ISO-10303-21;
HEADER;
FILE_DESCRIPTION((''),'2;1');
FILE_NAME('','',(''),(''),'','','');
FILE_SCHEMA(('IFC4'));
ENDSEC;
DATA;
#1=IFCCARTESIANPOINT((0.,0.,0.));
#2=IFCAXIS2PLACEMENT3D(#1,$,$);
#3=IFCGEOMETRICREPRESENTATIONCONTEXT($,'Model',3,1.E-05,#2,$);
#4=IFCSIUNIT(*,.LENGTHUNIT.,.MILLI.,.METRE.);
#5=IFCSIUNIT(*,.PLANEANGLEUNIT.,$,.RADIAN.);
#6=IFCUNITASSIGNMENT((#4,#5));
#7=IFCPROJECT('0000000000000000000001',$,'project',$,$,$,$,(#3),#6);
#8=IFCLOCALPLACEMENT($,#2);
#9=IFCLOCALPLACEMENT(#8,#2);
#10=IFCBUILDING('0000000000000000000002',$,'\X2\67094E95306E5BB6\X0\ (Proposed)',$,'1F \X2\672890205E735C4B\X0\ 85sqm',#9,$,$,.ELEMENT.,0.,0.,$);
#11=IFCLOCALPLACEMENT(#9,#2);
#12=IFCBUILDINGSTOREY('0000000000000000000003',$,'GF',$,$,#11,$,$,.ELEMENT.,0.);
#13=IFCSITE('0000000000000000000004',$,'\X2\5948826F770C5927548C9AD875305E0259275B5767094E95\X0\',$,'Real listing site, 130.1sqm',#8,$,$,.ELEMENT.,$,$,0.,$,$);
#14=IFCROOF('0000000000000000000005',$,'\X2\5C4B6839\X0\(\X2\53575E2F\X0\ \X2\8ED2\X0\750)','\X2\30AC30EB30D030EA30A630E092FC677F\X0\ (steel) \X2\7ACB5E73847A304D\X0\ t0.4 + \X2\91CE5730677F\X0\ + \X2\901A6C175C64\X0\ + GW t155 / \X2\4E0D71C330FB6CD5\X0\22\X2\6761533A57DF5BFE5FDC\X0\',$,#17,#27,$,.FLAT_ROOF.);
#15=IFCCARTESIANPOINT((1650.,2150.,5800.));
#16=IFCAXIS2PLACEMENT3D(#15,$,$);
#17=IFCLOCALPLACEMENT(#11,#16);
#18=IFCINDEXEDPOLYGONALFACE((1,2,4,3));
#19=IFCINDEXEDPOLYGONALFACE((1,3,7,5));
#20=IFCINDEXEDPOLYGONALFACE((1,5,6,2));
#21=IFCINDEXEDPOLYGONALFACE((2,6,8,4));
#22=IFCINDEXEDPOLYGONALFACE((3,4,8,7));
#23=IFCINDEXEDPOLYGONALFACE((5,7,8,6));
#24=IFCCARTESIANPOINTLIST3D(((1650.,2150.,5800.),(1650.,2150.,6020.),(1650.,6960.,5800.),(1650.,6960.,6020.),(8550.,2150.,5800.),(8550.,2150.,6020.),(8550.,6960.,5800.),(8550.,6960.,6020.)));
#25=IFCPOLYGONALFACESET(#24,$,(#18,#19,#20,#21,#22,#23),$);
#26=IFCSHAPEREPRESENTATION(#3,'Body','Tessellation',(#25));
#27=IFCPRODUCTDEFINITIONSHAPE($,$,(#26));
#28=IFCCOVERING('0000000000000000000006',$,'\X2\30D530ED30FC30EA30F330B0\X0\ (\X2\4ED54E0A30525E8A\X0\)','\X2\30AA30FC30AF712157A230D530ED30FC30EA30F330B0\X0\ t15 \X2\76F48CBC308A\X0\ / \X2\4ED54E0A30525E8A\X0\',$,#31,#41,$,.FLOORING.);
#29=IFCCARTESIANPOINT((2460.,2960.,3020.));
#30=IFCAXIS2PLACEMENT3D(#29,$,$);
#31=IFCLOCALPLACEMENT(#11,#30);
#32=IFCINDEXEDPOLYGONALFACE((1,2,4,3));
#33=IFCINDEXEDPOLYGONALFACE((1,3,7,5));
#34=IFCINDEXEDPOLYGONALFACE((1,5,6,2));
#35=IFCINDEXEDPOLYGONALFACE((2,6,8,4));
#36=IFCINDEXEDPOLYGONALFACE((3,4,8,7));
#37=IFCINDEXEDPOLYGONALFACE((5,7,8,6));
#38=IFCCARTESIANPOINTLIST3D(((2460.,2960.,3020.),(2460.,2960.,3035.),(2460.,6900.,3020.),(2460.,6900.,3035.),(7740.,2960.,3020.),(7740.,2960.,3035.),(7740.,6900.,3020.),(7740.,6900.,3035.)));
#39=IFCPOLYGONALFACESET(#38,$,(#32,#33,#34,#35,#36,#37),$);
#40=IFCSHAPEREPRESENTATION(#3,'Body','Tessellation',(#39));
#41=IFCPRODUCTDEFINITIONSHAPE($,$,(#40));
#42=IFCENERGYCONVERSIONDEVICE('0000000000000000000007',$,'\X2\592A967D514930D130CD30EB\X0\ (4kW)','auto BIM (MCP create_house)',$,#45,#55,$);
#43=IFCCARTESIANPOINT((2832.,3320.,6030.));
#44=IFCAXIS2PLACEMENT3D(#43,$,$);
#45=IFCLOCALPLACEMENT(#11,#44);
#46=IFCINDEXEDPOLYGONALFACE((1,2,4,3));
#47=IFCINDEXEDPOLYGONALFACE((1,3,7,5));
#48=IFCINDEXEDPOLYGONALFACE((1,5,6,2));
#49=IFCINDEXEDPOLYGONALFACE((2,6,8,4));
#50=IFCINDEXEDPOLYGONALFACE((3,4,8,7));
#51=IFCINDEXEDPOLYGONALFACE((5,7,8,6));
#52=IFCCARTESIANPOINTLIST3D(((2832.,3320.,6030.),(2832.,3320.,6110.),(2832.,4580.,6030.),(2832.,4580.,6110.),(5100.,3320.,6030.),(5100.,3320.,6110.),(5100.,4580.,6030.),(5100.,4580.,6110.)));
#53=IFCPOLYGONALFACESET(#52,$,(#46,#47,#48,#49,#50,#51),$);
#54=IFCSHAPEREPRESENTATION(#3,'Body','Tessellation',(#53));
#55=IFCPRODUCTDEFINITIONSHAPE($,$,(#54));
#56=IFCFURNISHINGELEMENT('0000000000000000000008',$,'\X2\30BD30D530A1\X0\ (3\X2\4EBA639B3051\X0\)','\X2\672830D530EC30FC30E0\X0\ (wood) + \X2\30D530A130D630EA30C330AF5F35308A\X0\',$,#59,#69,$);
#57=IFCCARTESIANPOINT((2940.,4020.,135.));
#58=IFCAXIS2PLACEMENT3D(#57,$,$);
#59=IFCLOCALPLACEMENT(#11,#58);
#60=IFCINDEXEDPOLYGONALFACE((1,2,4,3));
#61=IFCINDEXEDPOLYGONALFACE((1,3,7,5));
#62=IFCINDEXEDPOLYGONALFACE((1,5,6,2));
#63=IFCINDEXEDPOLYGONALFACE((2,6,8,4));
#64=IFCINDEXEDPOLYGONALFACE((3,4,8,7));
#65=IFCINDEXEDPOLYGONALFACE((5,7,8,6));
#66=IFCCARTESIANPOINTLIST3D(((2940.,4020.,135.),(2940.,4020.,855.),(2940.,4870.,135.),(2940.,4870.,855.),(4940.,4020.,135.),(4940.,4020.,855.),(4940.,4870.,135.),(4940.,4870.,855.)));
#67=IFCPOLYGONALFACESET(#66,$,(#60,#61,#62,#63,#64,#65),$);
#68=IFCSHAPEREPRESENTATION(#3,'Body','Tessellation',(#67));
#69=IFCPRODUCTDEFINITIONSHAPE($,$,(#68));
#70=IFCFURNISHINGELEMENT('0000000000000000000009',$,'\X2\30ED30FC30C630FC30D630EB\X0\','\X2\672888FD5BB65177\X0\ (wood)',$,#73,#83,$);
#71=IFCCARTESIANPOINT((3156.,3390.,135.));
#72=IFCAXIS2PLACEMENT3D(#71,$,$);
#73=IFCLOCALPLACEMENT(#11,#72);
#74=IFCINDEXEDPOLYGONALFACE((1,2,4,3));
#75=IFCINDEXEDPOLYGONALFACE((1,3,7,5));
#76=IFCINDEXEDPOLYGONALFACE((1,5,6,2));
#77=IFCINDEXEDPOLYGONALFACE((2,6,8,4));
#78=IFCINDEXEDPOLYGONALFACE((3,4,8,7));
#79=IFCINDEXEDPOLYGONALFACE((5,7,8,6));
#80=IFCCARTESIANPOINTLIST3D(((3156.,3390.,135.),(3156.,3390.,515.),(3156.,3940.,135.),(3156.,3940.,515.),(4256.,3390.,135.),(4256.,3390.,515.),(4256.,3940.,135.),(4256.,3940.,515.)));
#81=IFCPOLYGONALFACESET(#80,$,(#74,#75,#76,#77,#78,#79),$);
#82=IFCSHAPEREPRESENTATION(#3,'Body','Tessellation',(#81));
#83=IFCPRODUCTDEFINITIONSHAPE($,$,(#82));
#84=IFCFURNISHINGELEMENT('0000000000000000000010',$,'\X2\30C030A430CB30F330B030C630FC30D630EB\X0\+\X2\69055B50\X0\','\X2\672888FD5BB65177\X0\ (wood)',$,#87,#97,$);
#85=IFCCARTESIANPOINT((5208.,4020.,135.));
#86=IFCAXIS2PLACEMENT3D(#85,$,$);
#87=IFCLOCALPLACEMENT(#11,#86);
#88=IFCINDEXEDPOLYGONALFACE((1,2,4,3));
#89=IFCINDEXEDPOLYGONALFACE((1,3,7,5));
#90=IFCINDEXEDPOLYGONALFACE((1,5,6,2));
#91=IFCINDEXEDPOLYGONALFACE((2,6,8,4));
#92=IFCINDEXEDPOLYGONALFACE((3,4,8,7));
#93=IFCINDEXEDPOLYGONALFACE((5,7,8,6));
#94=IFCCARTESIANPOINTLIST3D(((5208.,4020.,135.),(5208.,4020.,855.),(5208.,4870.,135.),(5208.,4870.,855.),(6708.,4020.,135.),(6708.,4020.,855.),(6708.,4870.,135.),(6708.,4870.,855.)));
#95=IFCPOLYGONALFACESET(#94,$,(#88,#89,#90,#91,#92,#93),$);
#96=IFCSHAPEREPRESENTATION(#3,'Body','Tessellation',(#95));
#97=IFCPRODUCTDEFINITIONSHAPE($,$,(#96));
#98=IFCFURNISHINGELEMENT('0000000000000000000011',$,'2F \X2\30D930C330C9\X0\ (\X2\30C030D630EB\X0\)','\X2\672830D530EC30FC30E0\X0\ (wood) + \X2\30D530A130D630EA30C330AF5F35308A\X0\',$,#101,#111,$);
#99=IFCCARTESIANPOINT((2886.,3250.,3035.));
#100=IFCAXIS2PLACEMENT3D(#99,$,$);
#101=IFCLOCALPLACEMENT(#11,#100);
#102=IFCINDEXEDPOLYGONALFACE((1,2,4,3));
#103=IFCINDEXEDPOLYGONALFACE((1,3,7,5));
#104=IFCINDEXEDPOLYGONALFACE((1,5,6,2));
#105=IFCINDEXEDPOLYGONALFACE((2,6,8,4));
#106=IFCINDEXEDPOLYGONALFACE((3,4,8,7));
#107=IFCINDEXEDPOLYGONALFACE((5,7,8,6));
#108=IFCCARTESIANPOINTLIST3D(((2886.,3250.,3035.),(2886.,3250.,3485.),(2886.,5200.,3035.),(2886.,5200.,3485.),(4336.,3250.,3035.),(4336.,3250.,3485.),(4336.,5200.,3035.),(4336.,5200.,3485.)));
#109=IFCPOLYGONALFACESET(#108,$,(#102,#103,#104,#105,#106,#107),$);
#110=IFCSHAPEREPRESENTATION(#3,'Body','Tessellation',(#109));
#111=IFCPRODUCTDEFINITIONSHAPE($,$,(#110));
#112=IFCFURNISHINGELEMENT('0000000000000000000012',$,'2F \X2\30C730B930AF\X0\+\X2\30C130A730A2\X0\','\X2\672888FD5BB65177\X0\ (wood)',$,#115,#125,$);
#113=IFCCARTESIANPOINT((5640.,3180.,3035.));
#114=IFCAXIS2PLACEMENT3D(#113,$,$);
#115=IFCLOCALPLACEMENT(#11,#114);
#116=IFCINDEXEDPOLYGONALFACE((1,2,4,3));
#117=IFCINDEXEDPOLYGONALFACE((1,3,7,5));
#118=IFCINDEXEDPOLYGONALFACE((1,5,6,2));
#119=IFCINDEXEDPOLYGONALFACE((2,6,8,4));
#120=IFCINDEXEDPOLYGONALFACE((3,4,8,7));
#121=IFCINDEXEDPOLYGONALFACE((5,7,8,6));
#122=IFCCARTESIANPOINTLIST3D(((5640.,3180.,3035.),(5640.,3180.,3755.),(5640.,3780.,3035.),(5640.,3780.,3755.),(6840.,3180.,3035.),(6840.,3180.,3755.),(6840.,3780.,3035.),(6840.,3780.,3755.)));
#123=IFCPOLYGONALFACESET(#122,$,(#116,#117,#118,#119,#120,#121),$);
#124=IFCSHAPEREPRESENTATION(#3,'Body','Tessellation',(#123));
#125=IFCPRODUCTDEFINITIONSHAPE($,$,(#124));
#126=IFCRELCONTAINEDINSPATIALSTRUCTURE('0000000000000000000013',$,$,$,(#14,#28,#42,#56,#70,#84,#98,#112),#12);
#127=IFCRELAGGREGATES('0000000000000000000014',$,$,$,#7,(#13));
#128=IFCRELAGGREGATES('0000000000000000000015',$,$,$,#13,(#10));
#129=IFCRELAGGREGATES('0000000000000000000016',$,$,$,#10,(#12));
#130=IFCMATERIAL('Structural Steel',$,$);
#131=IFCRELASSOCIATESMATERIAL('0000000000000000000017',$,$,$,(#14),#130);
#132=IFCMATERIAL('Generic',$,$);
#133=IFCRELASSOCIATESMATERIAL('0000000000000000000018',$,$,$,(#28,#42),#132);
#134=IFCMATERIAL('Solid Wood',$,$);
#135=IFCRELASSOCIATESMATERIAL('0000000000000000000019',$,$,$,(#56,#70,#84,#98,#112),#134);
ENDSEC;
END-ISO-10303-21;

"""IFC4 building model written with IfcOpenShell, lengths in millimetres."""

from ifc_helpers import new_model, si_unit, frame, frame_2d, origin, place, context, project, spatial, rectangle, extrude, material, element, save


model = new_model("IFC4")

# Units and contexts
model_context = context("Model", 3, precision=1e-05, world=origin())
ifc_project = project(units=[si_unit("LENGTHUNIT", "METRE", prefix="MILLI"), si_unit("PLANEANGLEUNIT", "RADIAN")], contexts=[model_context])

# Site, building, storey
site_placement = place(None, origin())
site = spatial("IfcSite", under=ifc_project, at=site_placement, Name="奈良県大和高田市大字有井", ObjectType="Real listing site, 130.1sqm", CompositionType="ELEMENT", RefElevation=0.0)
building_placement = place(site_placement, origin())
building = spatial("IfcBuilding", under=site, at=building_placement, Name="有井の家 (Proposed)", ObjectType="1F 木造平屋 85sqm", CompositionType="ELEMENT", ElevationOfRefHeight=0.0, ElevationOfTerrain=0.0)
storey_placement = place(building_placement, origin())
storey = spatial("IfcBuildingStorey", under=building, at=storey_placement, Name="GF", CompositionType="ELEMENT", Elevation=0.0)

# Shared definitions
ifc_material_1 = material(Name="Solid Wood")

# Shared definitions
ifc_material_2 = material(Name="Generic")

# Roof
ifc_material_3 = material(Name="Structural Steel")
for number, where, name in (
    (1, (1650.0, 2150.0, 5800.0), "屋根(南帯 軒750)"),
):
    element("IfcRoof", number, at=place(storey_placement, frame(where)), inside=storey, material=ifc_material_3, Name=name, Description="ガルバリウム鋼板 (steel) 立平葺き t0.4 + 野地板 + 通気層 + GW t155 / 不燃・法22条区域対応", PredefinedType="FLAT_ROOF", context=model_context, shape_type="SweptSolid", body=[
        extrude(rectangle(XDim=6900.0, YDim=4810.0, at=frame_2d((3450.0, 2405.0))), frame((1650.0, 2150.0, 5800.0)), (0.0, 0.0, 1.0), 220.0),
    ])

# Covering
covering_placement = place(storey_placement, frame((2460.0, 2960.0, 3020.0)))
element("IfcCovering", 2, at=covering_placement, inside=storey, material=ifc_material_2, Name="フローリング (仕上げ床)", Description="オーク無垢フローリング t15 直貼り / 仕上げ床", PredefinedType="FLOORING", context=model_context, shape_type="SweptSolid", body=[
    extrude(rectangle(XDim=5280.0, YDim=3940.0, at=frame_2d((2640.0, 1970.0))), frame((2460.0, 2960.0, 3020.0)), (0.0, 0.0, 1.0), 15.0),
])

# Energy conversion device
energy_conversion_device_placement = place(storey_placement, frame((2832.0, 3320.0, 6030.0)))
element("IfcEnergyConversionDevice", 3, at=energy_conversion_device_placement, inside=storey, material=ifc_material_2, Name="太陽光パネル (4kW)", Description="auto BIM (MCP create_house)", context=model_context, shape_type="SweptSolid", body=[
    extrude(rectangle(XDim=2268.0, YDim=1260.0, at=frame_2d((1134.0, 630.0))), frame((2832.0, 3320.0, 6030.0)), (0.0, 0.0, 1.0), 80.0),
])

# Furnishing elements
furnishing_1_placement = place(storey_placement, frame((2940.0, 4020.0, 135.0)))
element("IfcFurnishingElement", 4, at=furnishing_1_placement, inside=storey, material=ifc_material_1, Name="ソファ (3人掛け)", Description="木フレーム (wood) + ファブリック張り", context=model_context, shape_type="SweptSolid", body=[
    extrude(rectangle(XDim=2000.0, YDim=850.0, at=frame_2d((1000.0, 425.0))), frame((2940.0, 4020.0, 135.0)), (0.0, 0.0, 1.0), 720.0),
])
furnishing_2_placement = place(storey_placement, frame((3156.0, 3390.0, 135.0)))
element("IfcFurnishingElement", 5, at=furnishing_2_placement, inside=storey, material=ifc_material_1, Name="ローテーブル", Description="木製家具 (wood)", context=model_context, shape_type="SweptSolid", body=[
    extrude(rectangle(XDim=1100.0, YDim=550.0, at=frame_2d((550.0, 275.0))), frame((3156.0, 3390.0, 135.0)), (0.0, 0.0, 1.0), 380.0),
])
furnishing_3_placement = place(storey_placement, frame((5208.0, 4020.0, 135.0)))
element("IfcFurnishingElement", 6, at=furnishing_3_placement, inside=storey, material=ifc_material_1, Name="ダイニングテーブル+椅子", Description="木製家具 (wood)", context=model_context, shape_type="SweptSolid", body=[
    extrude(rectangle(XDim=1500.0, YDim=850.0, at=frame_2d((750.0, 425.0))), frame((5208.0, 4020.0, 135.0)), (0.0, 0.0, 1.0), 720.0),
])
furnishing_4_placement = place(storey_placement, frame((2886.0, 3250.0, 3035.0)))
element("IfcFurnishingElement", 7, at=furnishing_4_placement, inside=storey, material=ifc_material_1, Name="2F ベッド (ダブル)", Description="木フレーム (wood) + ファブリック張り", context=model_context, shape_type="SweptSolid", body=[
    extrude(rectangle(XDim=1450.0, YDim=1950.0, at=frame_2d((725.0, 975.0))), frame((2886.0, 3250.0, 3035.0)), (0.0, 0.0, 1.0), 450.0),
])
furnishing_5_placement = place(storey_placement, frame((5640.0, 3180.0, 3035.0)))
element("IfcFurnishingElement", 8, at=furnishing_5_placement, inside=storey, material=ifc_material_1, Name="2F デスク+チェア", Description="木製家具 (wood)", context=model_context, shape_type="SweptSolid", body=[
    extrude(rectangle(XDim=1200.0, YDim=600.0, at=frame_2d((600.0, 300.0))), frame((5640.0, 3180.0, 3035.0)), (0.0, 0.0, 1.0), 720.0),
])

save(model, "model.ifc")
